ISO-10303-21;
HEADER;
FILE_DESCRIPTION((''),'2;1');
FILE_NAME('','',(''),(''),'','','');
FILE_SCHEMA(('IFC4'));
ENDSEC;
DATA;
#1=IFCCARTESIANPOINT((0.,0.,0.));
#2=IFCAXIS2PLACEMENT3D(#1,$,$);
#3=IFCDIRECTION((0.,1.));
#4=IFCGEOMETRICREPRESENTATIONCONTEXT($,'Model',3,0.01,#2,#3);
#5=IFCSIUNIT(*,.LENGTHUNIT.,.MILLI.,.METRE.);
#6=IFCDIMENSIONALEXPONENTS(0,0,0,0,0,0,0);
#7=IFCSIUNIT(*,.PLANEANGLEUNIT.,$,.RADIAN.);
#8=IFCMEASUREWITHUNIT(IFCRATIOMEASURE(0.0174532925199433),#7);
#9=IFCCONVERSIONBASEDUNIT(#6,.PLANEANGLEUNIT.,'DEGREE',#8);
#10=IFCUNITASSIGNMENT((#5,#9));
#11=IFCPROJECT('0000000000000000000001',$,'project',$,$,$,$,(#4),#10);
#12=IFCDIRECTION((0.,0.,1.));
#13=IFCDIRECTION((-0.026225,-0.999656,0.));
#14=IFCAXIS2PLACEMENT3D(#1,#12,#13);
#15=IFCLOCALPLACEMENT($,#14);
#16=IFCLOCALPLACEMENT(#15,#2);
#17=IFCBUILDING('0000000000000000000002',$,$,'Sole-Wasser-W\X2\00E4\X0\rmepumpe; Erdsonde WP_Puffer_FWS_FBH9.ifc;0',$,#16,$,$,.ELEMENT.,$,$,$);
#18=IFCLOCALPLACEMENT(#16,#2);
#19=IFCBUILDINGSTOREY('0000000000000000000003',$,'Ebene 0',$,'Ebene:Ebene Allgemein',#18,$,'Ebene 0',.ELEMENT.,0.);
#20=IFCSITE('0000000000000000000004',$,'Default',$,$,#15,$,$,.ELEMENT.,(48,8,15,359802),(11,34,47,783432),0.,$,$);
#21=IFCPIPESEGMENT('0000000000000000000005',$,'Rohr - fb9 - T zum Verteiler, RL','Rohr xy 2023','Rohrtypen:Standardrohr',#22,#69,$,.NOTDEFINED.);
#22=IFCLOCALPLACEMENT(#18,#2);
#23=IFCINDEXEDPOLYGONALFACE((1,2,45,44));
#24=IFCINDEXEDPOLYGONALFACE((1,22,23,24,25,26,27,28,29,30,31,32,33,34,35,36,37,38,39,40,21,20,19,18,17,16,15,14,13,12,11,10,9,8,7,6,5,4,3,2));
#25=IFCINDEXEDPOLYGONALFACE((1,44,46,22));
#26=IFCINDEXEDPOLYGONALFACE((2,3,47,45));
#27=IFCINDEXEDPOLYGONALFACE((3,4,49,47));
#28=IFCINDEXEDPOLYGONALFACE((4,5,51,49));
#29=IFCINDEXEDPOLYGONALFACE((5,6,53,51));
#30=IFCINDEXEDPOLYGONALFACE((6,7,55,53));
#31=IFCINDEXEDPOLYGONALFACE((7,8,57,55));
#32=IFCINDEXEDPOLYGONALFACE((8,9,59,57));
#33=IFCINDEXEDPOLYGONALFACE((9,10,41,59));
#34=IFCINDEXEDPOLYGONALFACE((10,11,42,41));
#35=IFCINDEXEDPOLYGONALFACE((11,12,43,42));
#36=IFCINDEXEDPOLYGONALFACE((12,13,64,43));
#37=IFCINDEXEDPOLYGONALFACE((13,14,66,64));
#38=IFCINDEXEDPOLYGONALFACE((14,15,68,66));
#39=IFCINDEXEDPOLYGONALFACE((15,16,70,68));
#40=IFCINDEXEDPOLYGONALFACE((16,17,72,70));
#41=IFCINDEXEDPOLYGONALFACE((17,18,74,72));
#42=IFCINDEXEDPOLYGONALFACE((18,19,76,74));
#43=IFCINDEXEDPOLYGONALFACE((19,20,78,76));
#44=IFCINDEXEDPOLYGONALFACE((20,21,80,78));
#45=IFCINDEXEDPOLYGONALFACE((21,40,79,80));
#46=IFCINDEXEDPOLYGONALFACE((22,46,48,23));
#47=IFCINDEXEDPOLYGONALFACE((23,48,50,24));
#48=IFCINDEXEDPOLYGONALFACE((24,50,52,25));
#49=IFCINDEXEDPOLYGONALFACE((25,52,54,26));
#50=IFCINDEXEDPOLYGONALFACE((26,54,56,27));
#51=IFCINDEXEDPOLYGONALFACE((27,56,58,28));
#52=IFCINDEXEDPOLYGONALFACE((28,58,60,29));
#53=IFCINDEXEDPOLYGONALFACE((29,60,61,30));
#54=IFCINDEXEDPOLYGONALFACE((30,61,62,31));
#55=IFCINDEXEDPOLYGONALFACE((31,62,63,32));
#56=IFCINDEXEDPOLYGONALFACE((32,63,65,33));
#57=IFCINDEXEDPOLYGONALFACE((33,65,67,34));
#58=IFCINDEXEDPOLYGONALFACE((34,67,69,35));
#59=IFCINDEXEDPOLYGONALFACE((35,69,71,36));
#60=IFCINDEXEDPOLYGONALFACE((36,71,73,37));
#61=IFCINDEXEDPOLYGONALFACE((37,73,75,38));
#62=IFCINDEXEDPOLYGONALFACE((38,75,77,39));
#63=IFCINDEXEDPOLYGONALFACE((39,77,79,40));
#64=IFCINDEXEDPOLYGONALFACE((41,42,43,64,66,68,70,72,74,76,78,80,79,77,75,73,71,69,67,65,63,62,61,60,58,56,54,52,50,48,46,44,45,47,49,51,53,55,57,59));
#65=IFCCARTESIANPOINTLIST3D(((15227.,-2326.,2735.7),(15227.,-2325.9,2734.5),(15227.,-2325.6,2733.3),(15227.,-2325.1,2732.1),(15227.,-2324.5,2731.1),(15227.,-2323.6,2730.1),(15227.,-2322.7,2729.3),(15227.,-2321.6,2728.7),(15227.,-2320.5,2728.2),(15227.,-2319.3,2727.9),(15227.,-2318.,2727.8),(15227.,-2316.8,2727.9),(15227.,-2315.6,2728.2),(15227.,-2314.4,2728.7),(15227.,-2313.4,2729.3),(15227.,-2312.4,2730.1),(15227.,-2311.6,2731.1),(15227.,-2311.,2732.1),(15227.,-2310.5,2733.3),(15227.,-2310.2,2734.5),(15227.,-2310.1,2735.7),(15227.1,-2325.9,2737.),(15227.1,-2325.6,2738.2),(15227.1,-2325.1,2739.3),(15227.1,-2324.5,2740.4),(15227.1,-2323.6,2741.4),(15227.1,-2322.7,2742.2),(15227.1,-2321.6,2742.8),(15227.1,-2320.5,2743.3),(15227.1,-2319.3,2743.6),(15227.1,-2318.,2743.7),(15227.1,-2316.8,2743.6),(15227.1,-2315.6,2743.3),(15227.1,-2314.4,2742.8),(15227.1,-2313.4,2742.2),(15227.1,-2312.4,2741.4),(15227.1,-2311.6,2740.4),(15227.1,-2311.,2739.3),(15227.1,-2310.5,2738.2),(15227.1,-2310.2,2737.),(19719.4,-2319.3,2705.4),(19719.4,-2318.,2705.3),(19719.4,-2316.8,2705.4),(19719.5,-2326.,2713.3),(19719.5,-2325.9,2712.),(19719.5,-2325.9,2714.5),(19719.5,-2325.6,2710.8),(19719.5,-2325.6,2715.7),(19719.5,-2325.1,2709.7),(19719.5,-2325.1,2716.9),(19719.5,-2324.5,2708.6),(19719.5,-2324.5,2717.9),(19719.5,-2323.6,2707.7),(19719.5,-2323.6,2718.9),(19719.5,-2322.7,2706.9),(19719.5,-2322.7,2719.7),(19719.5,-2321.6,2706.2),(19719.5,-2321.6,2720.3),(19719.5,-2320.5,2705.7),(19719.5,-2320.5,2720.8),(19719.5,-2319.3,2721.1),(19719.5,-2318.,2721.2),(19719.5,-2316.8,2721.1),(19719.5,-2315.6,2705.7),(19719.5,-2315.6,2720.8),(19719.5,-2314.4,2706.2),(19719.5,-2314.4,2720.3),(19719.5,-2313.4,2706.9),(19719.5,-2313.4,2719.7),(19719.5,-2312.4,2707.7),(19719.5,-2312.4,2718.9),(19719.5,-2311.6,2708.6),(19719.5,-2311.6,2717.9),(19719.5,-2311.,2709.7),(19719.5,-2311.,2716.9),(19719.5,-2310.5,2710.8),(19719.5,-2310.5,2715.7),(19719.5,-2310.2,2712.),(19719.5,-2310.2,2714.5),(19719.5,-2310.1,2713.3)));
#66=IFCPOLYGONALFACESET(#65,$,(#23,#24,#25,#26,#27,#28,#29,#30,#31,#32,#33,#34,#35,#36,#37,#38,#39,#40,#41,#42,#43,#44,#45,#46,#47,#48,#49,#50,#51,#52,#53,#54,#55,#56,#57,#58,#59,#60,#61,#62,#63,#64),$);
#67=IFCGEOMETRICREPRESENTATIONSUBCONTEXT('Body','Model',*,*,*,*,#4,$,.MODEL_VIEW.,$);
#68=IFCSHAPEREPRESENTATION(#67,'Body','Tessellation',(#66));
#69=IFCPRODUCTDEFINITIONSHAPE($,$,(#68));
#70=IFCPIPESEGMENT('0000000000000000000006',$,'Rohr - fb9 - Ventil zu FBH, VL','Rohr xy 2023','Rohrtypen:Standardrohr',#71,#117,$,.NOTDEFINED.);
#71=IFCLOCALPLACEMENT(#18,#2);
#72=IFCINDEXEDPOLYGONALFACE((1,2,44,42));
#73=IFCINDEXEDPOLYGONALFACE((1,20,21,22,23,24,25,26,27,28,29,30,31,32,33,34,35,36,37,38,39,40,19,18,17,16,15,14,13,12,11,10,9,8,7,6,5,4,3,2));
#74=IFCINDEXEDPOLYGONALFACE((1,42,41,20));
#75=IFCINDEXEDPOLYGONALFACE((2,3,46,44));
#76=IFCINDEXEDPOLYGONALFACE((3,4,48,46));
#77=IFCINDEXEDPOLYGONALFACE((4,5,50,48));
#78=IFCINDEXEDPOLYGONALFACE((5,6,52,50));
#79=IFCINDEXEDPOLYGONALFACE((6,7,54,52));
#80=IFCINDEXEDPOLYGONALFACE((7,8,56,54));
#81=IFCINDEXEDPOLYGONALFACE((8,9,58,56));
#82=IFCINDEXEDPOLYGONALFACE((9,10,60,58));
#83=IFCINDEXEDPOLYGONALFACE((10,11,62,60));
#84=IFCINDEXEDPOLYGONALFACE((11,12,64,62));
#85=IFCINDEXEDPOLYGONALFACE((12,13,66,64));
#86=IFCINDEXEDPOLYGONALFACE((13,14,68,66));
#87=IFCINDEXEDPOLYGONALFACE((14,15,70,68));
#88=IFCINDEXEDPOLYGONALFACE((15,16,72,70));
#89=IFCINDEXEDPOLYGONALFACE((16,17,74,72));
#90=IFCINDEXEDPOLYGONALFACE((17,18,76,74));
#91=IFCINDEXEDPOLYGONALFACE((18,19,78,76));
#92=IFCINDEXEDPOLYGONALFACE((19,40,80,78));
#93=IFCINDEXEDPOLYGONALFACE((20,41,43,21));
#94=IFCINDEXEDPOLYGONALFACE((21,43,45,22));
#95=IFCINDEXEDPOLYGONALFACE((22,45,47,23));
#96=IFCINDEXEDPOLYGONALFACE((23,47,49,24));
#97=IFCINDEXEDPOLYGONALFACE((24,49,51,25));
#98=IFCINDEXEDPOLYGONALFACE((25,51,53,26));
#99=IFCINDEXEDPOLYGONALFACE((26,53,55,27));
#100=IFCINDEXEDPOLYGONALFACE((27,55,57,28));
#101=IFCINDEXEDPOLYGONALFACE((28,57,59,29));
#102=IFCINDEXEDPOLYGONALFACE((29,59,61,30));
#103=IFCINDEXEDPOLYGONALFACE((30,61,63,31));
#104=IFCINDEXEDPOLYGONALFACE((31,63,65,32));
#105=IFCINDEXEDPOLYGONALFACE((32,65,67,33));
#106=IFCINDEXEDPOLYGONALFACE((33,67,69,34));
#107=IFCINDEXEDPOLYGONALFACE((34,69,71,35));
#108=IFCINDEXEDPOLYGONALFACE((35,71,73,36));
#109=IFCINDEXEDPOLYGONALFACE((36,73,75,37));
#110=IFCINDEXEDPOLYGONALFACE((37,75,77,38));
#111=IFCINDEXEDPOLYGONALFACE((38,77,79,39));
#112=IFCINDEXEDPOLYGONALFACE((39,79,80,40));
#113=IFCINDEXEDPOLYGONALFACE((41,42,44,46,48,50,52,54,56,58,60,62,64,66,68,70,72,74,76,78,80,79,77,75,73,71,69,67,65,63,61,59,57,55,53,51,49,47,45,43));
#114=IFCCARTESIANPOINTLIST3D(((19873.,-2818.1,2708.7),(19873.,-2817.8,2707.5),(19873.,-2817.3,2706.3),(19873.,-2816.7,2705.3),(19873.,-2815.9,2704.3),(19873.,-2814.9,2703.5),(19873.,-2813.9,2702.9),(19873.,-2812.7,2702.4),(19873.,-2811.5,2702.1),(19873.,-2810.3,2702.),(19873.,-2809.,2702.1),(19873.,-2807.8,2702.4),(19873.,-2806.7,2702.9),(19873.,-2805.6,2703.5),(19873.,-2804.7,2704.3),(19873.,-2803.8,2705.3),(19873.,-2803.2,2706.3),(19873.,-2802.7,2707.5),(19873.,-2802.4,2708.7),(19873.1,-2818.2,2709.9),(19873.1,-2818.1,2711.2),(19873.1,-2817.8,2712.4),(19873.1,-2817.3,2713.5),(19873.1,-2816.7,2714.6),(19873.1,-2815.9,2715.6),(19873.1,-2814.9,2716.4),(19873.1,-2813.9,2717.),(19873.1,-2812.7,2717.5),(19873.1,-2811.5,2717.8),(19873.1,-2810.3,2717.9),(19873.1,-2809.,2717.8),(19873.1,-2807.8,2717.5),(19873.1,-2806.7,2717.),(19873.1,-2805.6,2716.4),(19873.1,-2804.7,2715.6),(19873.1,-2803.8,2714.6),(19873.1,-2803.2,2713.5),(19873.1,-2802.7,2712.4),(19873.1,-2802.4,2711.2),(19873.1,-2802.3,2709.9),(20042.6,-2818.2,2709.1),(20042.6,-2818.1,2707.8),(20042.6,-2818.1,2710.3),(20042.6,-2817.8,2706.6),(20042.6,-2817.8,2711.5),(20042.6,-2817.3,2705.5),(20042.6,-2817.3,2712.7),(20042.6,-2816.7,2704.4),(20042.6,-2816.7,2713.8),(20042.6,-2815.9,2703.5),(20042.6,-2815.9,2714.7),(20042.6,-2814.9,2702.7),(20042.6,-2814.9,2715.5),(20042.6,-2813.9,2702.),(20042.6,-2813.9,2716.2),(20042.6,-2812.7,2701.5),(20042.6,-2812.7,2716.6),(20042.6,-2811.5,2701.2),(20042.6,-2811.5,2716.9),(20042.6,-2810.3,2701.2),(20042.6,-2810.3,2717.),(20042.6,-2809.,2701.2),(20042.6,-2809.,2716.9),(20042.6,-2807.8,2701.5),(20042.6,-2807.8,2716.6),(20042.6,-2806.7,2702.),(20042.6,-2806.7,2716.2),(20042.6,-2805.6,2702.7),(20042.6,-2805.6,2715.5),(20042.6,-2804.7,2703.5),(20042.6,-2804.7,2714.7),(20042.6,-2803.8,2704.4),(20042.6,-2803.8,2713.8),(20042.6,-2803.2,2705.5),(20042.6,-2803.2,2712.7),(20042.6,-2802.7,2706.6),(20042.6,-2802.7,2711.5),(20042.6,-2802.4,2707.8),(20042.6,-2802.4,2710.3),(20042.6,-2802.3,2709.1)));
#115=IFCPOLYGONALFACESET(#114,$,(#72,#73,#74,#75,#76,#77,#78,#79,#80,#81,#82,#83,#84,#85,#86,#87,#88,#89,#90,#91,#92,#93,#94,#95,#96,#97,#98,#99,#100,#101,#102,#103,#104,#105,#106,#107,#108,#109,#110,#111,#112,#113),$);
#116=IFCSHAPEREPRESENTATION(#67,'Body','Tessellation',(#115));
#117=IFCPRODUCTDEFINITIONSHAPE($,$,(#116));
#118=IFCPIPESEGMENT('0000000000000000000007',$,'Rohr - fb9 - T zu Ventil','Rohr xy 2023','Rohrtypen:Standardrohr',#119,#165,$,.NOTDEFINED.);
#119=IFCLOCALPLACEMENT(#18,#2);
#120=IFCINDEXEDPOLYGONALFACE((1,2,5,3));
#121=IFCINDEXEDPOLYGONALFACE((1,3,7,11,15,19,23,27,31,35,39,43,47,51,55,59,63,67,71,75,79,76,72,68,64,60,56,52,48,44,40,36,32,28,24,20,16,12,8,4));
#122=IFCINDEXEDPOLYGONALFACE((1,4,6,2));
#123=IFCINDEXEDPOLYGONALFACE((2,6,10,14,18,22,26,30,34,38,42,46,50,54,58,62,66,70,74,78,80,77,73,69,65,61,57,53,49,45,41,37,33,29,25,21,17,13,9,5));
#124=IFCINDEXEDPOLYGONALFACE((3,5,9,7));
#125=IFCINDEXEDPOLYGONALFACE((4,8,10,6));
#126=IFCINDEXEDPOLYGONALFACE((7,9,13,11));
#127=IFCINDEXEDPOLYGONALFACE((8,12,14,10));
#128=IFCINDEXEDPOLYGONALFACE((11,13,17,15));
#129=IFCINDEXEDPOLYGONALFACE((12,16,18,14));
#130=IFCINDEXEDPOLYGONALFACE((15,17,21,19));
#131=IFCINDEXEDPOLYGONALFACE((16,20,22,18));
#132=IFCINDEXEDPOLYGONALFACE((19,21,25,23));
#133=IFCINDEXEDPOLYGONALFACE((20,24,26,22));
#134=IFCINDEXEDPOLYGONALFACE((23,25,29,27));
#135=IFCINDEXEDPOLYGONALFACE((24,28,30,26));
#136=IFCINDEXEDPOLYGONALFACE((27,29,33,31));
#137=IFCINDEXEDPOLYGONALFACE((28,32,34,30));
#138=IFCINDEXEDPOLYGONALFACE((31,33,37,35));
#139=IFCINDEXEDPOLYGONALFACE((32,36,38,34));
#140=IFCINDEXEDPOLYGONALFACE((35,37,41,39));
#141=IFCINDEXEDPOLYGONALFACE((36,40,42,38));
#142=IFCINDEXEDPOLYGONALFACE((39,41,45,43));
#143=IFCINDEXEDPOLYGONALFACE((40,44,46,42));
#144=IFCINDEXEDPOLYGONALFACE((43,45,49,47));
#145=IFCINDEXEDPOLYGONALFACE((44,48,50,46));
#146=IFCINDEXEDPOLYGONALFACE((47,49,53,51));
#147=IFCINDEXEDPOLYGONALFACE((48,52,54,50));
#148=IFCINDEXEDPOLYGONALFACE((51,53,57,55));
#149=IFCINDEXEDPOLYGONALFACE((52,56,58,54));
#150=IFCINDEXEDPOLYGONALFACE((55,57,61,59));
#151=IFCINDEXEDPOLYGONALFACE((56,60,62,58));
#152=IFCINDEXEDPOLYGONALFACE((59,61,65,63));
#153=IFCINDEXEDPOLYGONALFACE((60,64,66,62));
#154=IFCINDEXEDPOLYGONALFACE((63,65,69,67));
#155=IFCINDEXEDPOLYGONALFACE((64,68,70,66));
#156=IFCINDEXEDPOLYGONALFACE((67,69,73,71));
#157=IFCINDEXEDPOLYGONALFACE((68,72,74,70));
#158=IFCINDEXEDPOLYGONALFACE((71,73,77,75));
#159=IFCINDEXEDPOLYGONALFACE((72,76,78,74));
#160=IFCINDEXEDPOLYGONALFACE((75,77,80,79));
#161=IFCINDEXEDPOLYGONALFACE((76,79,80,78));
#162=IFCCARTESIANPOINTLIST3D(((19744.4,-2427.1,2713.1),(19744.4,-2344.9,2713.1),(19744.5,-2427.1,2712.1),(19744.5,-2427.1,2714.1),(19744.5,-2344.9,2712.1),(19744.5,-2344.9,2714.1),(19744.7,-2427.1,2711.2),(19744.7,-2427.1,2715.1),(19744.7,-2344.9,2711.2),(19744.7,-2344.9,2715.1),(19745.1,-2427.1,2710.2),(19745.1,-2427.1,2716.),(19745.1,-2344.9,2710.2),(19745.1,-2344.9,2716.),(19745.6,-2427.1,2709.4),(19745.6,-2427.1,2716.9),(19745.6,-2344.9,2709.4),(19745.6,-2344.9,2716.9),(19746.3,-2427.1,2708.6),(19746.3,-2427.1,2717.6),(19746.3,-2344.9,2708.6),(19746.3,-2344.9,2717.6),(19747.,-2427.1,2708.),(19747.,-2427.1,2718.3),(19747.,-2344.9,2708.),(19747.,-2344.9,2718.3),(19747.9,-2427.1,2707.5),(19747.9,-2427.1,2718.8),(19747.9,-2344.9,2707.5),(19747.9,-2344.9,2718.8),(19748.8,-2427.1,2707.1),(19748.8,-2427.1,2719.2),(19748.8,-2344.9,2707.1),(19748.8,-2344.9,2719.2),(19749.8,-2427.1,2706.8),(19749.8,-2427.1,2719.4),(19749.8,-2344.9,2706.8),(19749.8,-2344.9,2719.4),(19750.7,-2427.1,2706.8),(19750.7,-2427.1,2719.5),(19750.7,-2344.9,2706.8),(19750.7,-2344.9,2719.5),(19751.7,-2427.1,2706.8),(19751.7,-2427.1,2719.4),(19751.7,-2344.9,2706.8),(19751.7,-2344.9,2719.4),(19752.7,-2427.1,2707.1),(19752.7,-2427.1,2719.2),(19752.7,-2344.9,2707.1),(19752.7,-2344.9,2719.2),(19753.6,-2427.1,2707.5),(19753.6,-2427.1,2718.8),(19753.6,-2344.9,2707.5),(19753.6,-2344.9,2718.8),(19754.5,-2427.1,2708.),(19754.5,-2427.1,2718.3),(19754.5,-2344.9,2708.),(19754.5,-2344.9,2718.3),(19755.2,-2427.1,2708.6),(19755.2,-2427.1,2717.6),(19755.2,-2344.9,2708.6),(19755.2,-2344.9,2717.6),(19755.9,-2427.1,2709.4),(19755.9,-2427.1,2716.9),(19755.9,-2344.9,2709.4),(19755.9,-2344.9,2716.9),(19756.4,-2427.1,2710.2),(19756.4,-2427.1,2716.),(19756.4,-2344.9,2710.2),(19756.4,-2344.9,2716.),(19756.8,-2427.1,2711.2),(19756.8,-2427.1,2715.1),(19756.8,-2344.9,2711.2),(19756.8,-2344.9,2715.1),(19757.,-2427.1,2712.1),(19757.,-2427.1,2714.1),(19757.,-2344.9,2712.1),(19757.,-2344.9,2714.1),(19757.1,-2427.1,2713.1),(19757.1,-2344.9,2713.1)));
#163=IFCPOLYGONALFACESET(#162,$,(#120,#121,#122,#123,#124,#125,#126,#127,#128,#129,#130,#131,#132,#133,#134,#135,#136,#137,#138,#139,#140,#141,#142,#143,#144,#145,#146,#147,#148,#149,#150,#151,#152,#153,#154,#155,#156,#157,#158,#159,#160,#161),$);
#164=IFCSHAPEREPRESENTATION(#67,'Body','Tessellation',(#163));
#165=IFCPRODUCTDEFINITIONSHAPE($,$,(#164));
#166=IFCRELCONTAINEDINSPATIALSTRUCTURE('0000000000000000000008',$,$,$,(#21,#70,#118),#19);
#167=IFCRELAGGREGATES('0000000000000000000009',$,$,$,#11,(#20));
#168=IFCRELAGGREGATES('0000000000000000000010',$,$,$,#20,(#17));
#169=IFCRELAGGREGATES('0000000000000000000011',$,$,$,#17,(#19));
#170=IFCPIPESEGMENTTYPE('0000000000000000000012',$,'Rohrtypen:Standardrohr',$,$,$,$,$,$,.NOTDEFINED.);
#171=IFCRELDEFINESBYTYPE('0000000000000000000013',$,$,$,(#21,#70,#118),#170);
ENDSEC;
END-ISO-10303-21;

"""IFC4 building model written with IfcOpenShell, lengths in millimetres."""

from ifc_helpers import new_model, entity, si_unit, converted_unit, direction, frame, origin, place, context, subcontext, project, spatial, indexed_curve, outline, extrude, type_object, element, save


model = new_model("IFC4")

# Units and contexts
model_context = context("Model", 3, precision=0.01, world=origin(), true_north=direction((0.0, 1.0)))
body_context = subcontext(model_context, "Body", "Model", "MODEL_VIEW")
ifc_project = project(units=[si_unit("LENGTHUNIT", "METRE", prefix="MILLI"), converted_unit("PLANEANGLEUNIT", "DEGREE", entity("IfcRatioMeasure", 0.0174532925199433), si_unit("PLANEANGLEUNIT", "RADIAN"), dimensions=[0, 0, 0, 0, 0, 0, 0])], contexts=[model_context])

# Site, building, storey
site_placement = place(None, frame((0.0, 0.0, 0.0), z_axis=(0.0, 0.0, 1.0), x_axis=(-0.026225, -0.999656, 0.0)))
site = spatial("IfcSite", under=ifc_project, at=site_placement, Name="Default", CompositionType="ELEMENT", RefLatitude=(48, 8, 15, 359802), RefLongitude=(11, 34, 47, 783432), RefElevation=0.0)
building_placement = place(site_placement, origin())
building = spatial("IfcBuilding", under=site, at=building_placement, Description="Sole-Wasser-Wärmepumpe; Erdsonde WP_Puffer_FWS_FBH9.ifc;0", CompositionType="ELEMENT")
storey_placement = place(building_placement, origin())
storey = spatial("IfcBuildingStorey", under=building, at=storey_placement, Name="Ebene 0", ObjectType="Ebene:Ebene Allgemein", LongName="Ebene 0", CompositionType="ELEMENT", Elevation=0.0)

# Pipe segments
pipe_segment_type = type_object("IfcPipeSegmentType", Name="Rohrtypen:Standardrohr", PredefinedType="NOTDEFINED")
pipe_segment_1_placement = place(storey_placement, origin())
element("IfcPipeSegment", 1, at=pipe_segment_1_placement, inside=storey, type_object=pipe_segment_type, Name="Rohr - fb9 - T zum Verteiler, RL", Description="Rohr xy 2023", ObjectType="Rohrtypen:Standardrohr", PredefinedType="NOTDEFINED", context=body_context, shape_type="SweptSolid", body=[
    extrude(outline(indexed_curve([(7.9, 0.0), (7.8, 1.2), (7.6, 2.5), (7.1, 3.6), (6.4, 4.7), (5.6, 5.6), (4.7, 6.4), (3.6, 7.1), (2.5, 7.6), (1.2, 7.8), (0.0, 7.9), (-1.2, 7.8), (-2.5, 7.6), (-3.6, 7.1), (-4.7, 6.4), (-5.6, 5.6), (-6.4, 4.7), (-7.1, 3.6), (-7.6, 2.5), (-7.8, 1.2), (-7.9, 0.0), (-7.8, -1.2), (-7.6, -2.5), (-7.1, -3.6), (-6.4, -4.7), (-5.6, -5.6), (-4.7, -6.4), (-3.6, -7.1), (-2.5, -7.6), (-1.2, -7.8), (0.0, -7.9), (1.2, -7.8), (2.5, -7.6), (3.6, -7.1), (4.7, -6.4), (5.6, -5.6), (6.4, -4.7), (7.1, -3.6), (7.6, -2.5), (7.8, -1.2), (7.9, 0.0)], self_intersect=False)), frame((15227.0, -2318.0, 2735.7), z_axis=(0.999988, 0.0, -0.005), x_axis=(0.0, 1.0, 0.0)), (0.0, 0.0, 1.0), 4492.5),
])
pipe_segment_2_placement = place(storey_placement, origin())
element("IfcPipeSegment", 2, at=pipe_segment_2_placement, inside=storey, type_object=pipe_segment_type, Name="Rohr - fb9 - Ventil zu FBH, VL", Description="Rohr xy 2023", ObjectType="Rohrtypen:Standardrohr", PredefinedType="NOTDEFINED", context=body_context, shape_type="SweptSolid", body=[
    extrude(outline(indexed_curve([(7.9, 0.0), (7.8, 1.2), (7.6, 2.5), (7.1, 3.6), (6.4, 4.7), (5.6, 5.6), (4.7, 6.4), (3.6, 7.1), (2.5, 7.6), (1.2, 7.8), (0.0, 7.9), (-1.2, 7.8), (-2.5, 7.6), (-3.6, 7.1), (-4.7, 6.4), (-5.6, 5.6), (-6.4, 4.7), (-7.1, 3.6), (-7.6, 2.5), (-7.8, 1.2), (-7.9, 0.0), (-7.8, -1.2), (-7.6, -2.5), (-7.1, -3.6), (-6.4, -4.7), (-5.6, -5.6), (-4.7, -6.4), (-3.6, -7.1), (-2.5, -7.6), (-1.2, -7.8), (0.0, -7.9), (1.2, -7.8), (2.5, -7.6), (3.6, -7.1), (4.7, -6.4), (5.6, -5.6), (6.4, -4.7), (7.1, -3.6), (7.6, -2.5), (7.8, -1.2), (7.9, 0.0)], self_intersect=False)), frame((19873.1, -2810.3, 2709.9), z_axis=(0.999988, 0.0, -0.005), x_axis=(0.0, 1.0, 0.0)), (0.0, 0.0, 1.0), 169.5),
])
pipe_segment_3_placement = place(storey_placement, origin())
element("IfcPipeSegment", 3, at=pipe_segment_3_placement, inside=storey, type_object=pipe_segment_type, Name="Rohr - fb9 - T zu Ventil", Description="Rohr xy 2023", ObjectType="Rohrtypen:Standardrohr", PredefinedType="NOTDEFINED", context=body_context, shape_type="SweptSolid", body=[
    extrude(outline(indexed_curve([(6.3, 0.0), (6.3, 1.0), (6.0, 2.0), (5.7, 2.9), (5.1, 3.7), (4.5, 4.5), (3.7, 5.1), (2.9, 5.7), (2.0, 6.0), (1.0, 6.3), (0.0, 6.4), (-1.0, 6.3), (-2.0, 6.0), (-2.9, 5.7), (-3.7, 5.1), (-4.5, 4.5), (-5.1, 3.7), (-5.7, 2.9), (-6.0, 2.0), (-6.3, 1.0), (-6.3, 0.0), (-6.3, -1.0), (-6.0, -2.0), (-5.7, -2.9), (-5.1, -3.7), (-4.5, -4.5), (-3.7, -5.1), (-2.9, -5.7), (-2.0, -6.0), (-1.0, -6.3), (0.0, -6.4), (1.0, -6.3), (2.0, -6.0), (2.9, -5.7), (3.7, -5.1), (4.5, -4.5), (5.1, -3.7), (5.7, -2.9), (6.0, -2.0), (6.3, -1.0), (6.3, 0.0)], self_intersect=False)), frame((19750.7, -2427.1, 2713.1), z_axis=(0.0, 1.0, 0.0), x_axis=(-1.0, 0.0, 0.0)), (0.0, 0.0, 1.0), 82.2),
])

save(model, "model.ifc")
